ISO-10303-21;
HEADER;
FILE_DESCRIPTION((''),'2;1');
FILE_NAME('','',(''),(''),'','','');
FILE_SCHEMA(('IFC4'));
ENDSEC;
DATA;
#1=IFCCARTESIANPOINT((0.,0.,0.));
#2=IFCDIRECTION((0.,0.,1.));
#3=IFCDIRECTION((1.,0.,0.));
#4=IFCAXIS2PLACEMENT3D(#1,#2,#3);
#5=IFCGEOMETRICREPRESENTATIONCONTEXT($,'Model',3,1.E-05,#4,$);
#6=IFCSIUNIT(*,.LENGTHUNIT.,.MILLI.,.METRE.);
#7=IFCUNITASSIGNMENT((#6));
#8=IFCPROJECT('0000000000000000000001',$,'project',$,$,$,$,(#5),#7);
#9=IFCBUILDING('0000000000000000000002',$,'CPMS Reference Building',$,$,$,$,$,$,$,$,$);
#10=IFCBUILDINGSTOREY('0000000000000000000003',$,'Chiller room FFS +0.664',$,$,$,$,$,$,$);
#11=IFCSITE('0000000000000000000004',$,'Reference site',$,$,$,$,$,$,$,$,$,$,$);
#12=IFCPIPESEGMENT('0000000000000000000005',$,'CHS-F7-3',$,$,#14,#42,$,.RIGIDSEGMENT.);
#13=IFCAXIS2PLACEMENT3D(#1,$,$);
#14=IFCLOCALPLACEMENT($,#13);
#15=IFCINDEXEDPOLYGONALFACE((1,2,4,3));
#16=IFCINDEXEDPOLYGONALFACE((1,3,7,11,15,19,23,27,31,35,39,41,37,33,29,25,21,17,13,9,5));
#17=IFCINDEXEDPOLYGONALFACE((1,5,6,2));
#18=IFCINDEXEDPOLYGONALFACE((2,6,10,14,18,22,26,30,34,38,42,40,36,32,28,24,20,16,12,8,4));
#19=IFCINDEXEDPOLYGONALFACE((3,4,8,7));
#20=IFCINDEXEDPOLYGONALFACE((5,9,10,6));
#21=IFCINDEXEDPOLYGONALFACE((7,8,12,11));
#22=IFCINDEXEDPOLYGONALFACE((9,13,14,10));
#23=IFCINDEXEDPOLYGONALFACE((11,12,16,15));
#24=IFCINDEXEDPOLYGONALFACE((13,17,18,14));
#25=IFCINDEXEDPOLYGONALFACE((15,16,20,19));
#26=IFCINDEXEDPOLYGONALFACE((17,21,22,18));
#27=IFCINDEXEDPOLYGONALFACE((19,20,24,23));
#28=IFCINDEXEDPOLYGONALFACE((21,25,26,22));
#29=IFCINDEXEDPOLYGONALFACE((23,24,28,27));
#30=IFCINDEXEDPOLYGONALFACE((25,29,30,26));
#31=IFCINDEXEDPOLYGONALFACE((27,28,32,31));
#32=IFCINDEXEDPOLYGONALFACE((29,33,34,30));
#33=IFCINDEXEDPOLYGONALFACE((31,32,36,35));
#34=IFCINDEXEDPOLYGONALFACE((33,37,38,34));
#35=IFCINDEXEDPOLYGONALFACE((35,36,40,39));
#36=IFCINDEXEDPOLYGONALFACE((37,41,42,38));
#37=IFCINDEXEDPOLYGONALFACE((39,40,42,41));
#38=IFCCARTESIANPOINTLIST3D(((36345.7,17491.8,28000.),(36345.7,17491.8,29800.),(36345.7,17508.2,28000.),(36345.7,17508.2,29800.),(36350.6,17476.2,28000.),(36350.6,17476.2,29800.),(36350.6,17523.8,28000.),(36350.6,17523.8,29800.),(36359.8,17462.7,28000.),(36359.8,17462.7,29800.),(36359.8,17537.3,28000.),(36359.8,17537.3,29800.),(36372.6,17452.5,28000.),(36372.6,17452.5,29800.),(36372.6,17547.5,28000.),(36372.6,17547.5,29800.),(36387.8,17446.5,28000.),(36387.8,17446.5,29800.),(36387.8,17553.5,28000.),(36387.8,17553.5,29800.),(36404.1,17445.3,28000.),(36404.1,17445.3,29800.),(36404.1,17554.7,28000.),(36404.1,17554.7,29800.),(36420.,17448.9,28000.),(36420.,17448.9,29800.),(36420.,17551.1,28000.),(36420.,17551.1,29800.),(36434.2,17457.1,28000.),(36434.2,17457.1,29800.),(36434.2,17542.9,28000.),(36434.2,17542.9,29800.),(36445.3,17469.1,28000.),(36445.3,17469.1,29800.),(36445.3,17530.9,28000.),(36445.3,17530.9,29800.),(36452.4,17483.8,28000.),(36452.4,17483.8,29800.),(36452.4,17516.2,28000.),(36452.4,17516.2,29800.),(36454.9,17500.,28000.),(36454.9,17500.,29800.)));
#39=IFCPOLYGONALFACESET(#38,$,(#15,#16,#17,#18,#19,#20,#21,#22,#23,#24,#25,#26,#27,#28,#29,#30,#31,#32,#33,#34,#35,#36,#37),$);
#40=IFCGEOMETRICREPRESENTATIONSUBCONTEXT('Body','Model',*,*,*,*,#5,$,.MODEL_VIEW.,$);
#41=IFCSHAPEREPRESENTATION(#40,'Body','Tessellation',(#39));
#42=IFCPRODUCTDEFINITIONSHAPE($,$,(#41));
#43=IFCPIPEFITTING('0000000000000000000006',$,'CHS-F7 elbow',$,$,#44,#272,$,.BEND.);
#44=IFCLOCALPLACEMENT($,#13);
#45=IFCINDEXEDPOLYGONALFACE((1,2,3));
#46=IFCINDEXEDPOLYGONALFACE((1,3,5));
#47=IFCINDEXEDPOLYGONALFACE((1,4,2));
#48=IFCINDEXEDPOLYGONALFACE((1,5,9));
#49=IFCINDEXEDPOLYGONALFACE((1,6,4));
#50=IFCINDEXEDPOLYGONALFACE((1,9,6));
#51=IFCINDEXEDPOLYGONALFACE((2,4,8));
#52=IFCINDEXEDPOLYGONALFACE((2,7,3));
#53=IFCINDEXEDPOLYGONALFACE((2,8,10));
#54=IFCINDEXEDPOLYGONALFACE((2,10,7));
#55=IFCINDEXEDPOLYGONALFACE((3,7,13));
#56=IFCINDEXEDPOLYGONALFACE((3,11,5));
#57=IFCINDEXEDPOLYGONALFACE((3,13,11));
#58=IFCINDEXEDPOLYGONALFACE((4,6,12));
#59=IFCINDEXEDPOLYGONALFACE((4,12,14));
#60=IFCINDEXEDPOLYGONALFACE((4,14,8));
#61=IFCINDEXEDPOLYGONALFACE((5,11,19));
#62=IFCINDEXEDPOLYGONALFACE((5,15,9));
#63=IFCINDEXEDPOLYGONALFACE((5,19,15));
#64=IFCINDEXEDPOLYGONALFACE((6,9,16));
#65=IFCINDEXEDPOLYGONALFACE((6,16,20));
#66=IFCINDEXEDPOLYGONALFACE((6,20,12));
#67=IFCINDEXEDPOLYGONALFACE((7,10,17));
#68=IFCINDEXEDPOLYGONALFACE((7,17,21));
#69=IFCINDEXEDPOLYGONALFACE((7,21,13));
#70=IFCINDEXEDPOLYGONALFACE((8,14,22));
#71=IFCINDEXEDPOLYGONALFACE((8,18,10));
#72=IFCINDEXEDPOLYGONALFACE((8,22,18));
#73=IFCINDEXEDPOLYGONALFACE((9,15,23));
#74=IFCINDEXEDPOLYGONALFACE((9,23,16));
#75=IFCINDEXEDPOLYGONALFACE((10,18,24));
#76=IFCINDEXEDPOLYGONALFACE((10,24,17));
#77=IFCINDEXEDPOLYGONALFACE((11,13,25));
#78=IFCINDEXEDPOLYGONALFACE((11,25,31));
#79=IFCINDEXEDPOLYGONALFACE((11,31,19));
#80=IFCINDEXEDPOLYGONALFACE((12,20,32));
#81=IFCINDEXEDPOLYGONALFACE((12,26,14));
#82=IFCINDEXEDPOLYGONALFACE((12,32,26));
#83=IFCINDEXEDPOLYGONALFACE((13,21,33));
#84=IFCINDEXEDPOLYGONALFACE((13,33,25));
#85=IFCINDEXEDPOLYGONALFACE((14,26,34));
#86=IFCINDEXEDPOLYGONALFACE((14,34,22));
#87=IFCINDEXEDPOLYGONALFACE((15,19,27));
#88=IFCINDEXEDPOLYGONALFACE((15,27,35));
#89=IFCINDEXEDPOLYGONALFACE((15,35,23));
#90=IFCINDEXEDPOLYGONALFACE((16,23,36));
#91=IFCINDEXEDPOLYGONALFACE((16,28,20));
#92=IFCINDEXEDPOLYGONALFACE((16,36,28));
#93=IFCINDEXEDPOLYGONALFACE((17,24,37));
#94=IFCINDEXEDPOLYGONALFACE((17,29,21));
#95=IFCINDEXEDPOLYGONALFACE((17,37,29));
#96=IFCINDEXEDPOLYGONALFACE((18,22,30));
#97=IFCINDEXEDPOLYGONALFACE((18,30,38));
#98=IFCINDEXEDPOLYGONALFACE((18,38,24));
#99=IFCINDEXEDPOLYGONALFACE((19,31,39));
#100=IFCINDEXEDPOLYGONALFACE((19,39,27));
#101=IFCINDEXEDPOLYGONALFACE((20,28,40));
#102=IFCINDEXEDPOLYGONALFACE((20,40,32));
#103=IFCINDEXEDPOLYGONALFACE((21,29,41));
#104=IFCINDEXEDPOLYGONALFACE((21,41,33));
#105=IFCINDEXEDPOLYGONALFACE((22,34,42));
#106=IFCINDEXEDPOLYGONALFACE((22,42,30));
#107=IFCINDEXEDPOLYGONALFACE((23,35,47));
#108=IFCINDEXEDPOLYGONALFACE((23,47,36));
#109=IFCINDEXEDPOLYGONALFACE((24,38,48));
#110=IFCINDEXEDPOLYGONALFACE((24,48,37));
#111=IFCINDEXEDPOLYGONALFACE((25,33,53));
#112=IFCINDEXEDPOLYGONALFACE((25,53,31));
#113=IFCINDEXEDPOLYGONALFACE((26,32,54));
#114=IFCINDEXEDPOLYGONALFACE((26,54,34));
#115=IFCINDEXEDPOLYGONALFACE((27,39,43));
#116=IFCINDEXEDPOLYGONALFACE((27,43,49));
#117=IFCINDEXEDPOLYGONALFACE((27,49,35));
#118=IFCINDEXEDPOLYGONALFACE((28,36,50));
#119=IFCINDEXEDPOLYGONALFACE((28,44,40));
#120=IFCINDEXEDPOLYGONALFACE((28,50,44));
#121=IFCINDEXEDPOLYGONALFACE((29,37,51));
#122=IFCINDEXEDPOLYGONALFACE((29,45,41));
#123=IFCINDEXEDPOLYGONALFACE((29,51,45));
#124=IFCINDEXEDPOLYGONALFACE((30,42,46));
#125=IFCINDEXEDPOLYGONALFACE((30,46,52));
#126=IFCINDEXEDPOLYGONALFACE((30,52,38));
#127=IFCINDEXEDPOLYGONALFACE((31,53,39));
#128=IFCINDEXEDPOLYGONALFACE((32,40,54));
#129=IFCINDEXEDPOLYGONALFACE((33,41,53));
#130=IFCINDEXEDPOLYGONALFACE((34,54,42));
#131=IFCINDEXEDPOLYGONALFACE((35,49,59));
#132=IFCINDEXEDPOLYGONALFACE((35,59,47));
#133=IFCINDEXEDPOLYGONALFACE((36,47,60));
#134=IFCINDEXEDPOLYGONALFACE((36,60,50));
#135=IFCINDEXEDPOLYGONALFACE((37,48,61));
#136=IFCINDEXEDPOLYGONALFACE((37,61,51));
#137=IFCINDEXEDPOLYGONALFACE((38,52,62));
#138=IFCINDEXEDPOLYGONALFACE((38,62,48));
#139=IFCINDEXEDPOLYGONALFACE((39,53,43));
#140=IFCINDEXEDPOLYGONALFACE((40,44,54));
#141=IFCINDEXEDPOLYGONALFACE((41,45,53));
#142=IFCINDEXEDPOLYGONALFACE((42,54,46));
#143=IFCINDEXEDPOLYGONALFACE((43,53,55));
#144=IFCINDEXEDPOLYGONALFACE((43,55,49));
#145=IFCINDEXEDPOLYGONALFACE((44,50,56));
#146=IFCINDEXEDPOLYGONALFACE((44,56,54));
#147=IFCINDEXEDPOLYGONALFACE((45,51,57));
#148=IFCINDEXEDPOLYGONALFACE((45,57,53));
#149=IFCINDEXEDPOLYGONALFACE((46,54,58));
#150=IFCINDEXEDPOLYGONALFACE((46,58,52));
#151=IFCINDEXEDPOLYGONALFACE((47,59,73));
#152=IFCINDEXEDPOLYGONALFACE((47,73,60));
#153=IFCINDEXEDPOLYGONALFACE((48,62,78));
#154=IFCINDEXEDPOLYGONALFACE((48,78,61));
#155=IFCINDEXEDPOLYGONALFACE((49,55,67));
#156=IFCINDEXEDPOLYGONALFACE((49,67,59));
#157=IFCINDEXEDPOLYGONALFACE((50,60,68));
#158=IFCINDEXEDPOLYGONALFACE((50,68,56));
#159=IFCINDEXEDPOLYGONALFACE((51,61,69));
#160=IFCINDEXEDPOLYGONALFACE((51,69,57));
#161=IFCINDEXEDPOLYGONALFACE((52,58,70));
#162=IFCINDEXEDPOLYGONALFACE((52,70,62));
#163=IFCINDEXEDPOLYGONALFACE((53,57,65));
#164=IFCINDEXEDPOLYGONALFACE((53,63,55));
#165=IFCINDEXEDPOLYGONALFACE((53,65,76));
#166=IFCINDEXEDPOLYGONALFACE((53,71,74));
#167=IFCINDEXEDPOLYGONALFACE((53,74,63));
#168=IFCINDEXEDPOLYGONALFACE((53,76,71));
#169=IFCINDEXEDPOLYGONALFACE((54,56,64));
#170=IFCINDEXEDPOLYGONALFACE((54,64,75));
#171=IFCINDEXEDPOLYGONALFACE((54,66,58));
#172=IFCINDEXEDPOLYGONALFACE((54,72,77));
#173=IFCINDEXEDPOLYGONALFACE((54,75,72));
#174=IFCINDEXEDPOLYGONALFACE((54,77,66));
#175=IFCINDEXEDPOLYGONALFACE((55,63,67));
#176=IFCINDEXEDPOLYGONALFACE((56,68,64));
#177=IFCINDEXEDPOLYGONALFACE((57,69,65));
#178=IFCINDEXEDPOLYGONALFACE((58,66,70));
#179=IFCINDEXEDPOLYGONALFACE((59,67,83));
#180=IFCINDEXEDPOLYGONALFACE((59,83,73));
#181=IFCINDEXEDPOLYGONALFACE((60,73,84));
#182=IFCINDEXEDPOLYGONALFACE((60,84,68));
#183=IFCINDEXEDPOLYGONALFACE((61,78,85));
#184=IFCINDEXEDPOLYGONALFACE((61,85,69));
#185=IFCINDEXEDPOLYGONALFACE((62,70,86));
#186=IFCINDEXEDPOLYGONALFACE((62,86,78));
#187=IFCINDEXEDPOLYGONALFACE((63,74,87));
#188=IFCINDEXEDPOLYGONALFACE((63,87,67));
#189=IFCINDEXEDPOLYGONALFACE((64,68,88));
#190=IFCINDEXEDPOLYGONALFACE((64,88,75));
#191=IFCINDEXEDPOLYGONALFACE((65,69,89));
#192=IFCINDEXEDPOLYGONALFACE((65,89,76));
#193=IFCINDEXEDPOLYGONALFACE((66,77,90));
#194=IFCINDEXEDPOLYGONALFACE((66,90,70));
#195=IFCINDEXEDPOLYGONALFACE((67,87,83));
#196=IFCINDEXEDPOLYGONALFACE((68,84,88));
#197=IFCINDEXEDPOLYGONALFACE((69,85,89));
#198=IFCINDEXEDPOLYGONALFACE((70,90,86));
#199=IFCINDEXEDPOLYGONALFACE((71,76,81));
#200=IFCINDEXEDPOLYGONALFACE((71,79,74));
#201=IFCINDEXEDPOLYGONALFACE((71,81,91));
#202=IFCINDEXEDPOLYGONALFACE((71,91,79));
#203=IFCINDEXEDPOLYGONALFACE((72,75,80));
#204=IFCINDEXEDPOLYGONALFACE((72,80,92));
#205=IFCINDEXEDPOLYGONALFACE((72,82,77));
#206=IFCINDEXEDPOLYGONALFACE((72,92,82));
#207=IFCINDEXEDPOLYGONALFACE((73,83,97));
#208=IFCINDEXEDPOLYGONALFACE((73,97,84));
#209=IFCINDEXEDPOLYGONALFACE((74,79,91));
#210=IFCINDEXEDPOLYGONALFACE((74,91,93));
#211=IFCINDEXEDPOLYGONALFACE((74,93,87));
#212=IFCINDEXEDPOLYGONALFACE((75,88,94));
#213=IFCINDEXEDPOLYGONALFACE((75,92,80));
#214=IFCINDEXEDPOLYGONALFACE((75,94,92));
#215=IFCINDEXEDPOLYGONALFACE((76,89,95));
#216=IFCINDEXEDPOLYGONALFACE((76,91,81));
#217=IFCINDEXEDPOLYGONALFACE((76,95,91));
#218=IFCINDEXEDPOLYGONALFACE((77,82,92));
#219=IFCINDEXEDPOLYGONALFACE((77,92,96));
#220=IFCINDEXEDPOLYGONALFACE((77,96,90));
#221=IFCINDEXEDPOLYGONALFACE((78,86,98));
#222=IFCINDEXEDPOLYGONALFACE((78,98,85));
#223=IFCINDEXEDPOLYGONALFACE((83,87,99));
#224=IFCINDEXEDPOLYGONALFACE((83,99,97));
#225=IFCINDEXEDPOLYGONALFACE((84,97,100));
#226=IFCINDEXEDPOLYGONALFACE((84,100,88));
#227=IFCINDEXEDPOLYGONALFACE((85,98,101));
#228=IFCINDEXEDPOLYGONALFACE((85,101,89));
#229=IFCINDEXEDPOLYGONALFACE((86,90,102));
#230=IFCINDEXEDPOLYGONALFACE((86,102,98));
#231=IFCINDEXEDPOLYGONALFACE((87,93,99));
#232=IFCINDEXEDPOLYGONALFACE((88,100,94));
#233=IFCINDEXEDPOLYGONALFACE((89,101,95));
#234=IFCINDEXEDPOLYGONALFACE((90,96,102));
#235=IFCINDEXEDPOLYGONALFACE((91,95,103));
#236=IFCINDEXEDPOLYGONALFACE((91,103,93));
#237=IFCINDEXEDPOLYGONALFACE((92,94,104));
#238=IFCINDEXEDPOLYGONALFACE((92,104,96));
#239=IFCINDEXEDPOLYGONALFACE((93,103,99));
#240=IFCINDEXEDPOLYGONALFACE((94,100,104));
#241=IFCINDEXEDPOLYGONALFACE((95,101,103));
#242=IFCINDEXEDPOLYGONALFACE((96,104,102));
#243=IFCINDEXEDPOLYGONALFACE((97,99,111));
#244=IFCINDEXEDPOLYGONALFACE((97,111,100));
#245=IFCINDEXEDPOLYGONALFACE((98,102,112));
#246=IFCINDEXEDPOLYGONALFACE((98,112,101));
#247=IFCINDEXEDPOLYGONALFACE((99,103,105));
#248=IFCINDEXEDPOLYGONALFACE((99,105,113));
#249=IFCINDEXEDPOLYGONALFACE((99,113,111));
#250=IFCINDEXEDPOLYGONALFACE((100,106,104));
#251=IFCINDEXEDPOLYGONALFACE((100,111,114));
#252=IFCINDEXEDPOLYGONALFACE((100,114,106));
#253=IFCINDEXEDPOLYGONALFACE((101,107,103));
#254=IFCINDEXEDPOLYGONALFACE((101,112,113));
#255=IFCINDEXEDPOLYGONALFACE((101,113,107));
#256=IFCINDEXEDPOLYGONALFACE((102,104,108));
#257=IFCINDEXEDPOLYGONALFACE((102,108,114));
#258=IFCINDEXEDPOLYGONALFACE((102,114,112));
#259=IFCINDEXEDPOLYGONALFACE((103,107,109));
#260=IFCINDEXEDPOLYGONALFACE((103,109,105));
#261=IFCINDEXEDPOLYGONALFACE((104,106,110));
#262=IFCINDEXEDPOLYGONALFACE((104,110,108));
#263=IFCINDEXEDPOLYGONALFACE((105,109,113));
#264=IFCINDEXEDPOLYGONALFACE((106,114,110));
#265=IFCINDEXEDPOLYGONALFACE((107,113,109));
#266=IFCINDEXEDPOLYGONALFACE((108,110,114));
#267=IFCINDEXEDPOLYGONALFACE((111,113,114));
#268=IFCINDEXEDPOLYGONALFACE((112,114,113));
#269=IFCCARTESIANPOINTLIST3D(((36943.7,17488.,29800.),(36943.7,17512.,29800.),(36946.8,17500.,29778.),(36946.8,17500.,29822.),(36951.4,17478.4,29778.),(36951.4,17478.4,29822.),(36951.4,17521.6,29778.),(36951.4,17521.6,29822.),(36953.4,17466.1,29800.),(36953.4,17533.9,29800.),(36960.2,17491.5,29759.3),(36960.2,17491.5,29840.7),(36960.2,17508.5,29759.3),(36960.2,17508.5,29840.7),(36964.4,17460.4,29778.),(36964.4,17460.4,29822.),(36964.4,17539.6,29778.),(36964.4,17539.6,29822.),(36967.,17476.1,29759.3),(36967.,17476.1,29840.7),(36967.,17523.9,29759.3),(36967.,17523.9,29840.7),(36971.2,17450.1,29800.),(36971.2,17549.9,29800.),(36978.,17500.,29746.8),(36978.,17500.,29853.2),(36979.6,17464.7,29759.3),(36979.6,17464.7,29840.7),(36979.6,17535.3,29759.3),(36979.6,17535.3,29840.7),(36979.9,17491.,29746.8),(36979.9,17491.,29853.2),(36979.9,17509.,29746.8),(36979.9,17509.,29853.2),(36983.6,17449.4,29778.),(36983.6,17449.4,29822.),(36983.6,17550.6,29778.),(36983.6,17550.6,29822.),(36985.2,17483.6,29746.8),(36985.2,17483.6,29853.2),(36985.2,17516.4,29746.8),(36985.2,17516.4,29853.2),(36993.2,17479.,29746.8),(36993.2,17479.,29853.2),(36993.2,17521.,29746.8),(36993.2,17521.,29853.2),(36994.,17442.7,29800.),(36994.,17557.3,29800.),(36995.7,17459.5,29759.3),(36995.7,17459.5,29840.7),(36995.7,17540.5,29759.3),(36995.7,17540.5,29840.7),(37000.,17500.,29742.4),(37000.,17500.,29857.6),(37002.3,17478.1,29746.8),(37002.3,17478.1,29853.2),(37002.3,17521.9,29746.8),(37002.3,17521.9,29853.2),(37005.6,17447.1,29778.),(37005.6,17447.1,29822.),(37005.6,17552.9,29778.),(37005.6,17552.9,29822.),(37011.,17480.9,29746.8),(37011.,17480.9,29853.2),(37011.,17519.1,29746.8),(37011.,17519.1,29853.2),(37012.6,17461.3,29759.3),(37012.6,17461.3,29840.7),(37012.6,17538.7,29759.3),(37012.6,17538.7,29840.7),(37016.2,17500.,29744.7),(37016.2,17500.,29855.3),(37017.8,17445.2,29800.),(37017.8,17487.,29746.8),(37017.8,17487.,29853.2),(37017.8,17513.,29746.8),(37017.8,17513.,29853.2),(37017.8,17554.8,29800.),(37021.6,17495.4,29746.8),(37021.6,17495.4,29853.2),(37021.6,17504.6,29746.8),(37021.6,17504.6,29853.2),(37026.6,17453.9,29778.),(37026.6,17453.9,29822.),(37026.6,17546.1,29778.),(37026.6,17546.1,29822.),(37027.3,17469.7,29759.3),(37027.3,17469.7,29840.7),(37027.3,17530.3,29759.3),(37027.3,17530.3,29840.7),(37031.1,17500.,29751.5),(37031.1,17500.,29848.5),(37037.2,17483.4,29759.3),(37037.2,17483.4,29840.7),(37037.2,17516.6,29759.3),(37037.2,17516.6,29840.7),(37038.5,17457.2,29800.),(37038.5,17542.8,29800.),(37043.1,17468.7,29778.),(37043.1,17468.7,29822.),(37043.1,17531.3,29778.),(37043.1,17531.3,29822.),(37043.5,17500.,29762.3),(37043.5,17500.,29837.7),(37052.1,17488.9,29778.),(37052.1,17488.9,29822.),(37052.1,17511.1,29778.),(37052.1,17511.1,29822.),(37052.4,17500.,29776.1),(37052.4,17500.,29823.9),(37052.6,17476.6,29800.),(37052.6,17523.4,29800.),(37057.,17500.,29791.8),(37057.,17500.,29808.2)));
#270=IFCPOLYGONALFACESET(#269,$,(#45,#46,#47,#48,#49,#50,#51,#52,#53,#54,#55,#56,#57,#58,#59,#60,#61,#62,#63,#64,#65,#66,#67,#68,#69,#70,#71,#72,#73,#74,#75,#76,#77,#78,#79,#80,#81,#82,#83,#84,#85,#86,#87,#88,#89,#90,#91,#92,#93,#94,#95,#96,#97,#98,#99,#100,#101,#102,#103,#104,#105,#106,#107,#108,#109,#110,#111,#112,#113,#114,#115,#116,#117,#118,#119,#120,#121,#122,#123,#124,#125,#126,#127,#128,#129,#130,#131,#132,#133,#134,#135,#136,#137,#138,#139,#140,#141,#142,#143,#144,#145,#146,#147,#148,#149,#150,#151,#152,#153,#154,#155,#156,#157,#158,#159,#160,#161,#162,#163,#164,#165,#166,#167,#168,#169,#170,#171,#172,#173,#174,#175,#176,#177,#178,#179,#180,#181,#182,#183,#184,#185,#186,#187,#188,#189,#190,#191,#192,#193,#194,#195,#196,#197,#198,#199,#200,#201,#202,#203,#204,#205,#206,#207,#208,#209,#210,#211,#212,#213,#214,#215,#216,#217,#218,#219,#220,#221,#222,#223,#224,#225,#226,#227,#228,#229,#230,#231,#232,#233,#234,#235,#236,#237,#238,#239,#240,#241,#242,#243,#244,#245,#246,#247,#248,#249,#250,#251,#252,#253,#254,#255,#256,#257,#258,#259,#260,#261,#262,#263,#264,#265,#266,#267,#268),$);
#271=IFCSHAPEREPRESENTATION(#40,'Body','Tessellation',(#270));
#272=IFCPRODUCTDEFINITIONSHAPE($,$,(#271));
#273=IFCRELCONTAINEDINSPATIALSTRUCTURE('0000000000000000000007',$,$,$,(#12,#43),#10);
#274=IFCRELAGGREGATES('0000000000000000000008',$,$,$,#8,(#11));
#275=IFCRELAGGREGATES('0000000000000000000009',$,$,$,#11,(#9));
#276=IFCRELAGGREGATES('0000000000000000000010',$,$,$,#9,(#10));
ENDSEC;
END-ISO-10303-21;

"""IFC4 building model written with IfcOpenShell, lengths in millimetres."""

from ifc_helpers import new_model, entity, si_unit, frame, origin_with_axes, origin_2d, place, context, subcontext, project, spatial, circle_curve, outline, extrude, element, save


model = new_model("IFC4")

# Units and contexts
model_context = context("Model", 3, precision=1e-05, world=origin_with_axes())
body_context = subcontext(model_context, "Body", "Model", "MODEL_VIEW")
ifc_project = project(units=[si_unit("LENGTHUNIT", "METRE", prefix="MILLI")], contexts=[model_context])

# Site, building, storey
site = spatial("IfcSite", under=ifc_project, Name="Reference site")
building = spatial("IfcBuilding", under=site, Name="CPMS Reference Building")
storey = spatial("IfcBuildingStorey", under=building, Name="Chiller room FFS +0.664")

# Pipe segment
pipe_segment_1_placement = place(None, origin_with_axes())
element("IfcPipeSegment", 1, at=pipe_segment_1_placement, inside=storey, Name="CHS-F7-3", PredefinedType="RIGIDSEGMENT", context=body_context, shape_type="SweptSolid", body=[
    extrude(outline(circle_curve(origin_2d(), 54.9)), frame((36400.0, 17500.0, 29800.0), z_axis=(0.0, 0.0, -1.0), x_axis=(1.0, 0.0, 0.0)), (0.0, 0.0, 1.0), 1800.0),
])

# Pipe fitting
pipe_fitting_1_placement = place(None, origin_with_axes())
element("IfcPipeFitting", 2, at=pipe_fitting_1_placement, inside=storey, Name="CHS-F7 elbow", PredefinedType="BEND", context=body_context, shape_type="CSG", body=[
    entity("IfcSphere", entity("IfcAxis2Placement3D", entity("IfcCartesianPoint", [37000.0, 17500.0, 29800.0]), entity("IfcDirection", [0.0, 0.0, 1.0]), entity("IfcDirection", [1.0, 0.0, 0.0])), 57.6),
])

save(model, "model.ifc")
